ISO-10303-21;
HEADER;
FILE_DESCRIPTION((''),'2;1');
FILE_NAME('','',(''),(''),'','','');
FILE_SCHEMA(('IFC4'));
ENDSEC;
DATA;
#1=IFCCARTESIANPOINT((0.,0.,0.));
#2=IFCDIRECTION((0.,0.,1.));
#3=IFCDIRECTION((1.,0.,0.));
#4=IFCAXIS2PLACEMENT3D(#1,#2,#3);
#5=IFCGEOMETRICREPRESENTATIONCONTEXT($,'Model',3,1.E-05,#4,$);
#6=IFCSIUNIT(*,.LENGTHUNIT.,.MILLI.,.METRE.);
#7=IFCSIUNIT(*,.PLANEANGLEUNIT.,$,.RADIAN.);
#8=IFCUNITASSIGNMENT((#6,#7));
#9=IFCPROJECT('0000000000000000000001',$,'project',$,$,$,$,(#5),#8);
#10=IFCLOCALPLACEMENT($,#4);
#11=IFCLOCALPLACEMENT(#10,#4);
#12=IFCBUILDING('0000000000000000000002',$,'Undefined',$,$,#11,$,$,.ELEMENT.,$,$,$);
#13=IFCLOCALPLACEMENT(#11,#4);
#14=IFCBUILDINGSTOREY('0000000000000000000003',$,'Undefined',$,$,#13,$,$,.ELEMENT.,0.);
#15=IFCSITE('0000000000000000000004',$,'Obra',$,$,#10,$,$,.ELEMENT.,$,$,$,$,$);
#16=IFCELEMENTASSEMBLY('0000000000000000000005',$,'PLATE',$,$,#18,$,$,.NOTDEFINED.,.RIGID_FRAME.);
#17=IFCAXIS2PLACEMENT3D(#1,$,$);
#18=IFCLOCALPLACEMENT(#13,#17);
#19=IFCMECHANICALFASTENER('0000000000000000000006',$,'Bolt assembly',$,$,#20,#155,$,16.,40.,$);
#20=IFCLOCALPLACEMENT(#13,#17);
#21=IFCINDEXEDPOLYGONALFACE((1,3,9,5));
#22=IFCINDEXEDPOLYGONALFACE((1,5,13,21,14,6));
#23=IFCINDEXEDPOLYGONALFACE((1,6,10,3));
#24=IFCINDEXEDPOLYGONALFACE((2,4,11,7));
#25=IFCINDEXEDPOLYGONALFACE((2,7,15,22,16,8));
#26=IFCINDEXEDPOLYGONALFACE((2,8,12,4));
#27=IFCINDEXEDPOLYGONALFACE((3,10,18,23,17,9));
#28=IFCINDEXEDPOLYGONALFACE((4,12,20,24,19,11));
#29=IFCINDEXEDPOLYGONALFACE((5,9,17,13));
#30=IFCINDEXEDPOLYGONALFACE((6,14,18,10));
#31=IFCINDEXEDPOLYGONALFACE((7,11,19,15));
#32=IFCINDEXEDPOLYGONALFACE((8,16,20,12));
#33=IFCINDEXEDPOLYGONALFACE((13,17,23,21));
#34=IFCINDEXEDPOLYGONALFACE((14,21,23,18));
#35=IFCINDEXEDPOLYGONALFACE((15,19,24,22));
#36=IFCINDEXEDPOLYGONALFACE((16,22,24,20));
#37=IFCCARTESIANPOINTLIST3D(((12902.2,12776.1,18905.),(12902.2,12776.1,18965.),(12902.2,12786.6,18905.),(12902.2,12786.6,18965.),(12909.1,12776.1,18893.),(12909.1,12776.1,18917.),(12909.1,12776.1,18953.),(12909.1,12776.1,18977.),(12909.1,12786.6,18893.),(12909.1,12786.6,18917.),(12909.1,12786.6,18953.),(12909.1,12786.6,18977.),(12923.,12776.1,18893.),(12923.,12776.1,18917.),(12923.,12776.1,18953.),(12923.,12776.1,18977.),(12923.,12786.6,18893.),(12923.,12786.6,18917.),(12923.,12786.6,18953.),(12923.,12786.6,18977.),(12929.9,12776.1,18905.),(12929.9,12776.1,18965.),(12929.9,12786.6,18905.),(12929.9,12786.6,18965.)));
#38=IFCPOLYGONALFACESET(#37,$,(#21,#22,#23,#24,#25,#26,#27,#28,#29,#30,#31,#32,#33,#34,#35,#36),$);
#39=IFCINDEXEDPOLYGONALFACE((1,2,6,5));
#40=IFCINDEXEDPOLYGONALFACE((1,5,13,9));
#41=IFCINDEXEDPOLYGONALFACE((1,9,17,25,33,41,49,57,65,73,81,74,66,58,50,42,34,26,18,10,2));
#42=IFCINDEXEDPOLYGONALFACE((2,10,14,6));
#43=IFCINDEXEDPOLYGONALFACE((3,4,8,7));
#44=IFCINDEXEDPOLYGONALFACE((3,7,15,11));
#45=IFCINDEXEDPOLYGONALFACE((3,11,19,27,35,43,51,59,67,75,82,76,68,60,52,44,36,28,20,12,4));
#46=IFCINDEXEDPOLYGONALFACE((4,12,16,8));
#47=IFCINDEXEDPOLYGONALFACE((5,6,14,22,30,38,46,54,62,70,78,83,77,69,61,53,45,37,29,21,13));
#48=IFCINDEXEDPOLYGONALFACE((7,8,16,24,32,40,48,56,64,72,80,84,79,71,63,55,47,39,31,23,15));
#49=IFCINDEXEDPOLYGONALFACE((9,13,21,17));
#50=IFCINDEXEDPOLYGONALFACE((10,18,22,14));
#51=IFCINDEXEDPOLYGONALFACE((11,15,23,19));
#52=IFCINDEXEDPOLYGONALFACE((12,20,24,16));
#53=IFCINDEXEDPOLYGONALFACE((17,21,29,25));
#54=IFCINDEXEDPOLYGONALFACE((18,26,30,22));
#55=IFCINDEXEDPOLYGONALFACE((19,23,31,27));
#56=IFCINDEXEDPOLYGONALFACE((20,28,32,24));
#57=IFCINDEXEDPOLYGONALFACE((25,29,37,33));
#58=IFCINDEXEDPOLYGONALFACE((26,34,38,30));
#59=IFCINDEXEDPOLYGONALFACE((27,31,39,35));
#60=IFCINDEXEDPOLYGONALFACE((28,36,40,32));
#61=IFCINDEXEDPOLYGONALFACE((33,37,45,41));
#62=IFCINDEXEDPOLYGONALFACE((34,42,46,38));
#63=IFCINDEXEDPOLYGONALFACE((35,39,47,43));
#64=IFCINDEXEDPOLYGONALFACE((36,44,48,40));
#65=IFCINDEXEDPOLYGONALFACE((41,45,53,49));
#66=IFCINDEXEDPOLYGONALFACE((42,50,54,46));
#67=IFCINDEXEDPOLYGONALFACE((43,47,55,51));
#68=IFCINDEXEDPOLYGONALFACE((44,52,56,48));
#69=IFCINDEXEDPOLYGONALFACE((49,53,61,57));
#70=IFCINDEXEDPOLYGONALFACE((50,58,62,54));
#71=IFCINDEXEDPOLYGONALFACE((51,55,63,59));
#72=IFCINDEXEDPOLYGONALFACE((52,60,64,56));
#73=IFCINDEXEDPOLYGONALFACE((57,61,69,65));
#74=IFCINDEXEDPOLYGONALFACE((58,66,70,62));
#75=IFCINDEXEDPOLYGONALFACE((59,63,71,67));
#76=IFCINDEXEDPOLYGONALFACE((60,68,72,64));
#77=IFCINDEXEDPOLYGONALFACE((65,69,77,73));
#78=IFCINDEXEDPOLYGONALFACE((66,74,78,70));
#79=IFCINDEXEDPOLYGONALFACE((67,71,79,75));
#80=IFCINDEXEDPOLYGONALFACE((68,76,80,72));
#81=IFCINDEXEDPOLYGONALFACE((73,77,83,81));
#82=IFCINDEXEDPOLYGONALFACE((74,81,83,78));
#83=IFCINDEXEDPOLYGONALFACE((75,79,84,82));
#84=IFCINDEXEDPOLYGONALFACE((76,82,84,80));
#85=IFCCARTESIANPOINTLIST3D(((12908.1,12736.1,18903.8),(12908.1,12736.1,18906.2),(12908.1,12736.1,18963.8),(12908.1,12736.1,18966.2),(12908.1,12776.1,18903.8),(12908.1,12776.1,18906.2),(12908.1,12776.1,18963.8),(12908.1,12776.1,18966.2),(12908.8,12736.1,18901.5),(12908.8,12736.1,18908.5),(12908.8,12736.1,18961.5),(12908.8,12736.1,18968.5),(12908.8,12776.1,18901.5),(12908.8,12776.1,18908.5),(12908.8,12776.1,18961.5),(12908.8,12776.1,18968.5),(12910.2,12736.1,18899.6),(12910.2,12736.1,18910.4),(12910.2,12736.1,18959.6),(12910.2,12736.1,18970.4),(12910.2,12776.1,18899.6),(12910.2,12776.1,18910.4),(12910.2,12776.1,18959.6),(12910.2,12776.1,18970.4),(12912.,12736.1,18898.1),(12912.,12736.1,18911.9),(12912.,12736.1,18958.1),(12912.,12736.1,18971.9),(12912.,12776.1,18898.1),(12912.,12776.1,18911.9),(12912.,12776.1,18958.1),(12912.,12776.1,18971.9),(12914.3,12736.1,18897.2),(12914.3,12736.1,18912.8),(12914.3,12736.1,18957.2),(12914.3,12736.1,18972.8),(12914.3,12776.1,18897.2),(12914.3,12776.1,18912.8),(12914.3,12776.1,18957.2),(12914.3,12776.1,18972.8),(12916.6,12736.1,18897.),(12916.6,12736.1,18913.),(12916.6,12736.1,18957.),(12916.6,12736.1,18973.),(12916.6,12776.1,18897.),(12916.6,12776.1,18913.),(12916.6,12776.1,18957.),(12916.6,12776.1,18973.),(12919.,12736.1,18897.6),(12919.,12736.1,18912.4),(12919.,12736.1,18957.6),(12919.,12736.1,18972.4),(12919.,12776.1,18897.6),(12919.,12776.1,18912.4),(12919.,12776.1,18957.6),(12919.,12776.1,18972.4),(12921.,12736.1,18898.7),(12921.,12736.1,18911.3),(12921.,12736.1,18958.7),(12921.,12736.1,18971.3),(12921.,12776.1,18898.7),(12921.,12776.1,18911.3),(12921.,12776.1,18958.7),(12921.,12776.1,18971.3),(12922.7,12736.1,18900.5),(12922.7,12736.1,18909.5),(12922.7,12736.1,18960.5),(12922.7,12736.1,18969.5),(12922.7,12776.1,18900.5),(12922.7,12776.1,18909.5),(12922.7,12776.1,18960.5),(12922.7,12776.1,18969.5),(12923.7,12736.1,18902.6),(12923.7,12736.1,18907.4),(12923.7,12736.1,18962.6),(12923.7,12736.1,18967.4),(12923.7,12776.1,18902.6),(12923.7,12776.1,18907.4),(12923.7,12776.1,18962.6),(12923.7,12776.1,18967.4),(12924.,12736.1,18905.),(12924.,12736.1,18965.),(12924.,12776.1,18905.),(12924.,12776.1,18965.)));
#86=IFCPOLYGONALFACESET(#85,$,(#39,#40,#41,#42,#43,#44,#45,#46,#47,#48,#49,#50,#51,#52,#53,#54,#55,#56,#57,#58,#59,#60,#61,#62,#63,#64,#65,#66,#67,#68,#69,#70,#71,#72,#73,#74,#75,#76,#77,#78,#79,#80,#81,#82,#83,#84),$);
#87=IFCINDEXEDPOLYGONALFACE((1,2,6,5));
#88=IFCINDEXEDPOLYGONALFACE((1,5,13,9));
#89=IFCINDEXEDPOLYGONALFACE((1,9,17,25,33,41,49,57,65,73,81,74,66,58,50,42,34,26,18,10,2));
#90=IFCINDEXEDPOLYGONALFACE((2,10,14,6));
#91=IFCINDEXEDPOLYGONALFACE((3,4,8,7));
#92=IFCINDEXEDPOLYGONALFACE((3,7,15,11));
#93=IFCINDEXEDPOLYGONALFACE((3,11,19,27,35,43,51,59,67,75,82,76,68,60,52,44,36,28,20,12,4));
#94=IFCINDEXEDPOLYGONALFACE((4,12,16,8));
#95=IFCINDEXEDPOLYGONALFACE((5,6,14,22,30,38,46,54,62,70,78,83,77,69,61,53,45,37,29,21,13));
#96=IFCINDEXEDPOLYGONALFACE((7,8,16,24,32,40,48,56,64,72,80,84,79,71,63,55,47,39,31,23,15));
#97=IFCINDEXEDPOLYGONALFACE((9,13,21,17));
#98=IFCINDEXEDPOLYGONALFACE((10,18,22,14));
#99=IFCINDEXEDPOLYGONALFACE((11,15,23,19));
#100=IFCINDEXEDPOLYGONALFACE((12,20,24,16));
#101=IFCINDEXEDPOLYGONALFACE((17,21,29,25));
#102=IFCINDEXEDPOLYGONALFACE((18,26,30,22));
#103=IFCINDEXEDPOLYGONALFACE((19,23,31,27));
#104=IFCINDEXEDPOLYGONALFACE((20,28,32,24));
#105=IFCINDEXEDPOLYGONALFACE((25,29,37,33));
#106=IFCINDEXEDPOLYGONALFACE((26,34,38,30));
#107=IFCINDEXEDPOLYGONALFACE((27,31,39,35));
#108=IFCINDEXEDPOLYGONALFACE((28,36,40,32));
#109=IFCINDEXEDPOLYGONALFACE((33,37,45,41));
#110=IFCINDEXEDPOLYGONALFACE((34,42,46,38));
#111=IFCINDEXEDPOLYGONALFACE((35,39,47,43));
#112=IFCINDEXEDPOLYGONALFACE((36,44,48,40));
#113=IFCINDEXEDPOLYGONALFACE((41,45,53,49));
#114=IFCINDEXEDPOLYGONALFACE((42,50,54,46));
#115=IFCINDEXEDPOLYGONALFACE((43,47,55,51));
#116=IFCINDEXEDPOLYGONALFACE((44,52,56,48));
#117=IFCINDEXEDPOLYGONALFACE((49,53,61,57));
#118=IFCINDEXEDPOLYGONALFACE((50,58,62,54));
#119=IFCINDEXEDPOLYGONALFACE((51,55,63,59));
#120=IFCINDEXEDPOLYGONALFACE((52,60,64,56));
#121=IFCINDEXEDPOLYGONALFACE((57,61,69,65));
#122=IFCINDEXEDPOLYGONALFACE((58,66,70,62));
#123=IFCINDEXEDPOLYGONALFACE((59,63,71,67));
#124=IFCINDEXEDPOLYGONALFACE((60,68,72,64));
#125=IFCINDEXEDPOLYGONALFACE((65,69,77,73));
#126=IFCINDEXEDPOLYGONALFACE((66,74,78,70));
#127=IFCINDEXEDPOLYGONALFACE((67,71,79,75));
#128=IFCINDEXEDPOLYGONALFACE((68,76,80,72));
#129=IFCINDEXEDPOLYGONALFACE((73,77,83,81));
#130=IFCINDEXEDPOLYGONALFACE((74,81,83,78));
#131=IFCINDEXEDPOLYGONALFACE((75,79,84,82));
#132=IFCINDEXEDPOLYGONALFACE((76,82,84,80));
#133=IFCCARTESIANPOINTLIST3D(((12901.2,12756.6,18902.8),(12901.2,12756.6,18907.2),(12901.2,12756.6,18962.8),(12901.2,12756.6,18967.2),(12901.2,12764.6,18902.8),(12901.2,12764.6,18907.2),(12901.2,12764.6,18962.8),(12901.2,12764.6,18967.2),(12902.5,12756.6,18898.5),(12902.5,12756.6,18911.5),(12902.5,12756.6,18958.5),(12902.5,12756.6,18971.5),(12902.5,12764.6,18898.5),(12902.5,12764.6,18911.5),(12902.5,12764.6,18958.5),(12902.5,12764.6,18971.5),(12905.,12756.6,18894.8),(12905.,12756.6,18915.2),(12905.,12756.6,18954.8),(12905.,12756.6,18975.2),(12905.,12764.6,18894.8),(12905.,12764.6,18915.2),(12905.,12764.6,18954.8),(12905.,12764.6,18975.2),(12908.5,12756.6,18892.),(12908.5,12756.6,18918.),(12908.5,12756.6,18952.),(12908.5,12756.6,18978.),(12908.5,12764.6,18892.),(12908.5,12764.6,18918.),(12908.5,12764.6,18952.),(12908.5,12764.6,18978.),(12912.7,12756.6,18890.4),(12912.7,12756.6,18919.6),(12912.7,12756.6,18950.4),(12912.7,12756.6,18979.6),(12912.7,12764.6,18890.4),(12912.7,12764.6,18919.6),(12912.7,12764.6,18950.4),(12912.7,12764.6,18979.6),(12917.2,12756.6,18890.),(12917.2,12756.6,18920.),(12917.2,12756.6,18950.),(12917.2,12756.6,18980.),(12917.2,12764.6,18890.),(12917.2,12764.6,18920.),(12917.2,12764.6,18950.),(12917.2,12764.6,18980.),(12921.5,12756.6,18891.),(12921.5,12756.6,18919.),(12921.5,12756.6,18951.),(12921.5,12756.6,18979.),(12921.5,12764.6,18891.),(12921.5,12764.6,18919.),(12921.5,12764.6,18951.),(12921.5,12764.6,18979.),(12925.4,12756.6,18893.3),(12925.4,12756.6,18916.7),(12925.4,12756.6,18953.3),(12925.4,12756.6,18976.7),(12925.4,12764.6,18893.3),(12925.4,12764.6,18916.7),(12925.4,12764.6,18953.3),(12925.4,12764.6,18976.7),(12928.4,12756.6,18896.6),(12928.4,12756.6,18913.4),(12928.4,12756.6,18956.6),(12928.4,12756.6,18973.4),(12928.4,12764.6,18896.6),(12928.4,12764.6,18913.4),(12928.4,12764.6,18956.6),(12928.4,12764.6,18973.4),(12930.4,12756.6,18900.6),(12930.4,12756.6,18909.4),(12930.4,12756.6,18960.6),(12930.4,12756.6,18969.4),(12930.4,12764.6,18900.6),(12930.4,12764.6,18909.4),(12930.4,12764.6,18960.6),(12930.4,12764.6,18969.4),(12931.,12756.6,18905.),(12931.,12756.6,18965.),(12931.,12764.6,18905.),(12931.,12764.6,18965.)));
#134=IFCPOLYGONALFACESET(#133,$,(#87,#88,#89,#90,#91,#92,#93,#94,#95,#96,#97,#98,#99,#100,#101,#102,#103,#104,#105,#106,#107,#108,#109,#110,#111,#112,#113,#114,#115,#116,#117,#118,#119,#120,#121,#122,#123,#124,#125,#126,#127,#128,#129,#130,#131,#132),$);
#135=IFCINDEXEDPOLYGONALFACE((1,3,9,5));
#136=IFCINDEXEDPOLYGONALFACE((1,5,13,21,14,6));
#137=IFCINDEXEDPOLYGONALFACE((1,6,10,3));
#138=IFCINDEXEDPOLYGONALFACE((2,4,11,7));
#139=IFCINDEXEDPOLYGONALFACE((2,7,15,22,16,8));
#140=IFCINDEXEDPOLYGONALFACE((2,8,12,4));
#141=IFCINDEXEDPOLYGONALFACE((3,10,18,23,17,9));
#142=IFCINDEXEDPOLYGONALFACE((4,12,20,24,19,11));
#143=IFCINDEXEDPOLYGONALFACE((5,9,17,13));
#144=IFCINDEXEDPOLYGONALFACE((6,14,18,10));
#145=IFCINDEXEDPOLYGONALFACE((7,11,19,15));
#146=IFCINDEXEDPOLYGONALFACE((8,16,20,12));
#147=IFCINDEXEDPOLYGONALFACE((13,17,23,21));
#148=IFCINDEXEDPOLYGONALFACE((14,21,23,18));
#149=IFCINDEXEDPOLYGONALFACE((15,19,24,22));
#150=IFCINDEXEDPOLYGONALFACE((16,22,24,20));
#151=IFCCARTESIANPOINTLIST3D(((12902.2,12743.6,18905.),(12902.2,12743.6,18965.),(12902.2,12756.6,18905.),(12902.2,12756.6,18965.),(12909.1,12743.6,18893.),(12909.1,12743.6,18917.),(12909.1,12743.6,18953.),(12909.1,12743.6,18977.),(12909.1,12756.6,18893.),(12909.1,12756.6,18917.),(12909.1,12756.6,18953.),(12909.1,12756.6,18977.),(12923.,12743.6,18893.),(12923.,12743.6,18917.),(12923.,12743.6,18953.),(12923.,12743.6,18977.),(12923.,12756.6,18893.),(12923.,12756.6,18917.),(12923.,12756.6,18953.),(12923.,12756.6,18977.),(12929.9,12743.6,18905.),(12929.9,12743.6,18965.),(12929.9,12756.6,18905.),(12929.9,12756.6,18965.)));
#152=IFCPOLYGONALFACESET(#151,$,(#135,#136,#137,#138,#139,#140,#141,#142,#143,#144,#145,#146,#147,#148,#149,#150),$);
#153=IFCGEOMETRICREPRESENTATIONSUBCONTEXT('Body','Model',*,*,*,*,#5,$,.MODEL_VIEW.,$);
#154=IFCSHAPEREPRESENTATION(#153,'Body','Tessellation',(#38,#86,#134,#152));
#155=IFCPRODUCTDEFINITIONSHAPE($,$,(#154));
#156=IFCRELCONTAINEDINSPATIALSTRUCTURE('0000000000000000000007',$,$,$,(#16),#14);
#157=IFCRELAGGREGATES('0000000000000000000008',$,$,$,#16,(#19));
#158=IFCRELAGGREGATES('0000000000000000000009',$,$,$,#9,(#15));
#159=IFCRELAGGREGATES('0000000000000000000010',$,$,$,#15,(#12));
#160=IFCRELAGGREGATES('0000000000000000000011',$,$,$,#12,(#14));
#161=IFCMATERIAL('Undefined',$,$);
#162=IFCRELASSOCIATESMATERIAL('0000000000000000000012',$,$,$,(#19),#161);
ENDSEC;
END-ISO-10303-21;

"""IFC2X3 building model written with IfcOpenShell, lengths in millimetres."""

from ifc_helpers import new_model, si_unit, frame, origin_with_axes, origin_2d_with_axis, place, context, subcontext, project, spatial, polyline, circle, outline, extrude, source, transform, mapped, material, element, aggregate, save


model = new_model("IFC2X3")

# Units and contexts
model_context = context("Model", 3, precision=1e-05, world=origin_with_axes())
body_context = subcontext(model_context, "Body", "Model", "MODEL_VIEW")
ifc_project = project(units=[si_unit("LENGTHUNIT", "METRE", prefix="MILLI"), si_unit("PLANEANGLEUNIT", "RADIAN")], contexts=[model_context])

# Site, building, storey
site_placement = place(None, origin_with_axes())
site = spatial("IfcSite", under=ifc_project, at=site_placement, Name="Obra", CompositionType="ELEMENT")
building_placement = place(site_placement, origin_with_axes())
building = spatial("IfcBuilding", under=site, at=building_placement, Name="Undefined", CompositionType="ELEMENT")
storey_placement = place(building_placement, origin_with_axes())
storey = spatial("IfcBuildingStorey", under=building, at=storey_placement, Name="Undefined", CompositionType="ELEMENT", Elevation=0.0)

# Element assembly
assembly_1_placement = place(storey_placement, origin_with_axes())
assembly_1 = element("IfcElementAssembly", 1, at=assembly_1_placement, inside=storey, Name="PLATE", AssemblyPlace="NOTDEFINED", PredefinedType="RIGID_FRAME")

# Mechanical fastener
ifc_material_1 = material(Name="Undefined")
shared_shape_1 = source(origin_with_axes(), body_context, "Body", "SweptSolid", [
    extrude(outline(polyline([(13.9, 0.0), (6.9, 12.0), (-6.9, 12.0), (-13.9, 0.0), (-6.9, -12.0), (6.9, -12.0), (13.9, 0.0)])), frame((0.0, -16.6, 0.0), z_axis=(0.0, 1.0, 0.0), x_axis=(1.0, 0.0, 0.0)), (0.0, 0.0, 1.0), 10.6),
    extrude(circle(Radius=8.0, at=origin_2d_with_axis()), frame((0.0, -6.0, 0.0), z_axis=(0.0, 1.0, 0.0), x_axis=(1.0, 0.0, 0.0)), (0.0, 0.0, 1.0), 40.0),
    extrude(circle(Radius=15.0, at=origin_2d_with_axis()), frame((0.0, 5.5, 0.0), z_axis=(0.0, 1.0, 0.0), x_axis=(1.0, 0.0, 0.0)), (0.0, 0.0, 1.0), 8.0),
    extrude(outline(polyline([(13.9, 0.0), (6.9, 12.0), (-6.9, 12.0), (-13.9, 0.0), (-6.9, -12.0), (6.9, -12.0), (13.9, 0.0)])), frame((0.0, 13.5, 0.0), z_axis=(0.0, 1.0, 0.0), x_axis=(1.0, 0.0, 0.0)), (0.0, 0.0, 1.0), 13.0),
])
mechanical_fastener_1_placement = place(assembly_1_placement, frame((12916.0, 12770.1, 18935.0), z_axis=(0.0, 0.0, -1.0), x_axis=(1.0, 0.0, 0.0)))
mechanical_fastener_1 = element("IfcMechanicalFastener", 2, at=mechanical_fastener_1_placement, material=ifc_material_1, Name="Bolt assembly", NominalDiameter=16.0, NominalLength=40.0, context=body_context, shape_type="MappedRepresentation", body=[
    mapped(shared_shape_1, transform((0.0, 0.0, 30.0))),
    mapped(shared_shape_1, transform((0.0, 0.0, -30.0))),
])
aggregate(assembly_1, [mechanical_fastener_1])

save(model, "model.ifc")
